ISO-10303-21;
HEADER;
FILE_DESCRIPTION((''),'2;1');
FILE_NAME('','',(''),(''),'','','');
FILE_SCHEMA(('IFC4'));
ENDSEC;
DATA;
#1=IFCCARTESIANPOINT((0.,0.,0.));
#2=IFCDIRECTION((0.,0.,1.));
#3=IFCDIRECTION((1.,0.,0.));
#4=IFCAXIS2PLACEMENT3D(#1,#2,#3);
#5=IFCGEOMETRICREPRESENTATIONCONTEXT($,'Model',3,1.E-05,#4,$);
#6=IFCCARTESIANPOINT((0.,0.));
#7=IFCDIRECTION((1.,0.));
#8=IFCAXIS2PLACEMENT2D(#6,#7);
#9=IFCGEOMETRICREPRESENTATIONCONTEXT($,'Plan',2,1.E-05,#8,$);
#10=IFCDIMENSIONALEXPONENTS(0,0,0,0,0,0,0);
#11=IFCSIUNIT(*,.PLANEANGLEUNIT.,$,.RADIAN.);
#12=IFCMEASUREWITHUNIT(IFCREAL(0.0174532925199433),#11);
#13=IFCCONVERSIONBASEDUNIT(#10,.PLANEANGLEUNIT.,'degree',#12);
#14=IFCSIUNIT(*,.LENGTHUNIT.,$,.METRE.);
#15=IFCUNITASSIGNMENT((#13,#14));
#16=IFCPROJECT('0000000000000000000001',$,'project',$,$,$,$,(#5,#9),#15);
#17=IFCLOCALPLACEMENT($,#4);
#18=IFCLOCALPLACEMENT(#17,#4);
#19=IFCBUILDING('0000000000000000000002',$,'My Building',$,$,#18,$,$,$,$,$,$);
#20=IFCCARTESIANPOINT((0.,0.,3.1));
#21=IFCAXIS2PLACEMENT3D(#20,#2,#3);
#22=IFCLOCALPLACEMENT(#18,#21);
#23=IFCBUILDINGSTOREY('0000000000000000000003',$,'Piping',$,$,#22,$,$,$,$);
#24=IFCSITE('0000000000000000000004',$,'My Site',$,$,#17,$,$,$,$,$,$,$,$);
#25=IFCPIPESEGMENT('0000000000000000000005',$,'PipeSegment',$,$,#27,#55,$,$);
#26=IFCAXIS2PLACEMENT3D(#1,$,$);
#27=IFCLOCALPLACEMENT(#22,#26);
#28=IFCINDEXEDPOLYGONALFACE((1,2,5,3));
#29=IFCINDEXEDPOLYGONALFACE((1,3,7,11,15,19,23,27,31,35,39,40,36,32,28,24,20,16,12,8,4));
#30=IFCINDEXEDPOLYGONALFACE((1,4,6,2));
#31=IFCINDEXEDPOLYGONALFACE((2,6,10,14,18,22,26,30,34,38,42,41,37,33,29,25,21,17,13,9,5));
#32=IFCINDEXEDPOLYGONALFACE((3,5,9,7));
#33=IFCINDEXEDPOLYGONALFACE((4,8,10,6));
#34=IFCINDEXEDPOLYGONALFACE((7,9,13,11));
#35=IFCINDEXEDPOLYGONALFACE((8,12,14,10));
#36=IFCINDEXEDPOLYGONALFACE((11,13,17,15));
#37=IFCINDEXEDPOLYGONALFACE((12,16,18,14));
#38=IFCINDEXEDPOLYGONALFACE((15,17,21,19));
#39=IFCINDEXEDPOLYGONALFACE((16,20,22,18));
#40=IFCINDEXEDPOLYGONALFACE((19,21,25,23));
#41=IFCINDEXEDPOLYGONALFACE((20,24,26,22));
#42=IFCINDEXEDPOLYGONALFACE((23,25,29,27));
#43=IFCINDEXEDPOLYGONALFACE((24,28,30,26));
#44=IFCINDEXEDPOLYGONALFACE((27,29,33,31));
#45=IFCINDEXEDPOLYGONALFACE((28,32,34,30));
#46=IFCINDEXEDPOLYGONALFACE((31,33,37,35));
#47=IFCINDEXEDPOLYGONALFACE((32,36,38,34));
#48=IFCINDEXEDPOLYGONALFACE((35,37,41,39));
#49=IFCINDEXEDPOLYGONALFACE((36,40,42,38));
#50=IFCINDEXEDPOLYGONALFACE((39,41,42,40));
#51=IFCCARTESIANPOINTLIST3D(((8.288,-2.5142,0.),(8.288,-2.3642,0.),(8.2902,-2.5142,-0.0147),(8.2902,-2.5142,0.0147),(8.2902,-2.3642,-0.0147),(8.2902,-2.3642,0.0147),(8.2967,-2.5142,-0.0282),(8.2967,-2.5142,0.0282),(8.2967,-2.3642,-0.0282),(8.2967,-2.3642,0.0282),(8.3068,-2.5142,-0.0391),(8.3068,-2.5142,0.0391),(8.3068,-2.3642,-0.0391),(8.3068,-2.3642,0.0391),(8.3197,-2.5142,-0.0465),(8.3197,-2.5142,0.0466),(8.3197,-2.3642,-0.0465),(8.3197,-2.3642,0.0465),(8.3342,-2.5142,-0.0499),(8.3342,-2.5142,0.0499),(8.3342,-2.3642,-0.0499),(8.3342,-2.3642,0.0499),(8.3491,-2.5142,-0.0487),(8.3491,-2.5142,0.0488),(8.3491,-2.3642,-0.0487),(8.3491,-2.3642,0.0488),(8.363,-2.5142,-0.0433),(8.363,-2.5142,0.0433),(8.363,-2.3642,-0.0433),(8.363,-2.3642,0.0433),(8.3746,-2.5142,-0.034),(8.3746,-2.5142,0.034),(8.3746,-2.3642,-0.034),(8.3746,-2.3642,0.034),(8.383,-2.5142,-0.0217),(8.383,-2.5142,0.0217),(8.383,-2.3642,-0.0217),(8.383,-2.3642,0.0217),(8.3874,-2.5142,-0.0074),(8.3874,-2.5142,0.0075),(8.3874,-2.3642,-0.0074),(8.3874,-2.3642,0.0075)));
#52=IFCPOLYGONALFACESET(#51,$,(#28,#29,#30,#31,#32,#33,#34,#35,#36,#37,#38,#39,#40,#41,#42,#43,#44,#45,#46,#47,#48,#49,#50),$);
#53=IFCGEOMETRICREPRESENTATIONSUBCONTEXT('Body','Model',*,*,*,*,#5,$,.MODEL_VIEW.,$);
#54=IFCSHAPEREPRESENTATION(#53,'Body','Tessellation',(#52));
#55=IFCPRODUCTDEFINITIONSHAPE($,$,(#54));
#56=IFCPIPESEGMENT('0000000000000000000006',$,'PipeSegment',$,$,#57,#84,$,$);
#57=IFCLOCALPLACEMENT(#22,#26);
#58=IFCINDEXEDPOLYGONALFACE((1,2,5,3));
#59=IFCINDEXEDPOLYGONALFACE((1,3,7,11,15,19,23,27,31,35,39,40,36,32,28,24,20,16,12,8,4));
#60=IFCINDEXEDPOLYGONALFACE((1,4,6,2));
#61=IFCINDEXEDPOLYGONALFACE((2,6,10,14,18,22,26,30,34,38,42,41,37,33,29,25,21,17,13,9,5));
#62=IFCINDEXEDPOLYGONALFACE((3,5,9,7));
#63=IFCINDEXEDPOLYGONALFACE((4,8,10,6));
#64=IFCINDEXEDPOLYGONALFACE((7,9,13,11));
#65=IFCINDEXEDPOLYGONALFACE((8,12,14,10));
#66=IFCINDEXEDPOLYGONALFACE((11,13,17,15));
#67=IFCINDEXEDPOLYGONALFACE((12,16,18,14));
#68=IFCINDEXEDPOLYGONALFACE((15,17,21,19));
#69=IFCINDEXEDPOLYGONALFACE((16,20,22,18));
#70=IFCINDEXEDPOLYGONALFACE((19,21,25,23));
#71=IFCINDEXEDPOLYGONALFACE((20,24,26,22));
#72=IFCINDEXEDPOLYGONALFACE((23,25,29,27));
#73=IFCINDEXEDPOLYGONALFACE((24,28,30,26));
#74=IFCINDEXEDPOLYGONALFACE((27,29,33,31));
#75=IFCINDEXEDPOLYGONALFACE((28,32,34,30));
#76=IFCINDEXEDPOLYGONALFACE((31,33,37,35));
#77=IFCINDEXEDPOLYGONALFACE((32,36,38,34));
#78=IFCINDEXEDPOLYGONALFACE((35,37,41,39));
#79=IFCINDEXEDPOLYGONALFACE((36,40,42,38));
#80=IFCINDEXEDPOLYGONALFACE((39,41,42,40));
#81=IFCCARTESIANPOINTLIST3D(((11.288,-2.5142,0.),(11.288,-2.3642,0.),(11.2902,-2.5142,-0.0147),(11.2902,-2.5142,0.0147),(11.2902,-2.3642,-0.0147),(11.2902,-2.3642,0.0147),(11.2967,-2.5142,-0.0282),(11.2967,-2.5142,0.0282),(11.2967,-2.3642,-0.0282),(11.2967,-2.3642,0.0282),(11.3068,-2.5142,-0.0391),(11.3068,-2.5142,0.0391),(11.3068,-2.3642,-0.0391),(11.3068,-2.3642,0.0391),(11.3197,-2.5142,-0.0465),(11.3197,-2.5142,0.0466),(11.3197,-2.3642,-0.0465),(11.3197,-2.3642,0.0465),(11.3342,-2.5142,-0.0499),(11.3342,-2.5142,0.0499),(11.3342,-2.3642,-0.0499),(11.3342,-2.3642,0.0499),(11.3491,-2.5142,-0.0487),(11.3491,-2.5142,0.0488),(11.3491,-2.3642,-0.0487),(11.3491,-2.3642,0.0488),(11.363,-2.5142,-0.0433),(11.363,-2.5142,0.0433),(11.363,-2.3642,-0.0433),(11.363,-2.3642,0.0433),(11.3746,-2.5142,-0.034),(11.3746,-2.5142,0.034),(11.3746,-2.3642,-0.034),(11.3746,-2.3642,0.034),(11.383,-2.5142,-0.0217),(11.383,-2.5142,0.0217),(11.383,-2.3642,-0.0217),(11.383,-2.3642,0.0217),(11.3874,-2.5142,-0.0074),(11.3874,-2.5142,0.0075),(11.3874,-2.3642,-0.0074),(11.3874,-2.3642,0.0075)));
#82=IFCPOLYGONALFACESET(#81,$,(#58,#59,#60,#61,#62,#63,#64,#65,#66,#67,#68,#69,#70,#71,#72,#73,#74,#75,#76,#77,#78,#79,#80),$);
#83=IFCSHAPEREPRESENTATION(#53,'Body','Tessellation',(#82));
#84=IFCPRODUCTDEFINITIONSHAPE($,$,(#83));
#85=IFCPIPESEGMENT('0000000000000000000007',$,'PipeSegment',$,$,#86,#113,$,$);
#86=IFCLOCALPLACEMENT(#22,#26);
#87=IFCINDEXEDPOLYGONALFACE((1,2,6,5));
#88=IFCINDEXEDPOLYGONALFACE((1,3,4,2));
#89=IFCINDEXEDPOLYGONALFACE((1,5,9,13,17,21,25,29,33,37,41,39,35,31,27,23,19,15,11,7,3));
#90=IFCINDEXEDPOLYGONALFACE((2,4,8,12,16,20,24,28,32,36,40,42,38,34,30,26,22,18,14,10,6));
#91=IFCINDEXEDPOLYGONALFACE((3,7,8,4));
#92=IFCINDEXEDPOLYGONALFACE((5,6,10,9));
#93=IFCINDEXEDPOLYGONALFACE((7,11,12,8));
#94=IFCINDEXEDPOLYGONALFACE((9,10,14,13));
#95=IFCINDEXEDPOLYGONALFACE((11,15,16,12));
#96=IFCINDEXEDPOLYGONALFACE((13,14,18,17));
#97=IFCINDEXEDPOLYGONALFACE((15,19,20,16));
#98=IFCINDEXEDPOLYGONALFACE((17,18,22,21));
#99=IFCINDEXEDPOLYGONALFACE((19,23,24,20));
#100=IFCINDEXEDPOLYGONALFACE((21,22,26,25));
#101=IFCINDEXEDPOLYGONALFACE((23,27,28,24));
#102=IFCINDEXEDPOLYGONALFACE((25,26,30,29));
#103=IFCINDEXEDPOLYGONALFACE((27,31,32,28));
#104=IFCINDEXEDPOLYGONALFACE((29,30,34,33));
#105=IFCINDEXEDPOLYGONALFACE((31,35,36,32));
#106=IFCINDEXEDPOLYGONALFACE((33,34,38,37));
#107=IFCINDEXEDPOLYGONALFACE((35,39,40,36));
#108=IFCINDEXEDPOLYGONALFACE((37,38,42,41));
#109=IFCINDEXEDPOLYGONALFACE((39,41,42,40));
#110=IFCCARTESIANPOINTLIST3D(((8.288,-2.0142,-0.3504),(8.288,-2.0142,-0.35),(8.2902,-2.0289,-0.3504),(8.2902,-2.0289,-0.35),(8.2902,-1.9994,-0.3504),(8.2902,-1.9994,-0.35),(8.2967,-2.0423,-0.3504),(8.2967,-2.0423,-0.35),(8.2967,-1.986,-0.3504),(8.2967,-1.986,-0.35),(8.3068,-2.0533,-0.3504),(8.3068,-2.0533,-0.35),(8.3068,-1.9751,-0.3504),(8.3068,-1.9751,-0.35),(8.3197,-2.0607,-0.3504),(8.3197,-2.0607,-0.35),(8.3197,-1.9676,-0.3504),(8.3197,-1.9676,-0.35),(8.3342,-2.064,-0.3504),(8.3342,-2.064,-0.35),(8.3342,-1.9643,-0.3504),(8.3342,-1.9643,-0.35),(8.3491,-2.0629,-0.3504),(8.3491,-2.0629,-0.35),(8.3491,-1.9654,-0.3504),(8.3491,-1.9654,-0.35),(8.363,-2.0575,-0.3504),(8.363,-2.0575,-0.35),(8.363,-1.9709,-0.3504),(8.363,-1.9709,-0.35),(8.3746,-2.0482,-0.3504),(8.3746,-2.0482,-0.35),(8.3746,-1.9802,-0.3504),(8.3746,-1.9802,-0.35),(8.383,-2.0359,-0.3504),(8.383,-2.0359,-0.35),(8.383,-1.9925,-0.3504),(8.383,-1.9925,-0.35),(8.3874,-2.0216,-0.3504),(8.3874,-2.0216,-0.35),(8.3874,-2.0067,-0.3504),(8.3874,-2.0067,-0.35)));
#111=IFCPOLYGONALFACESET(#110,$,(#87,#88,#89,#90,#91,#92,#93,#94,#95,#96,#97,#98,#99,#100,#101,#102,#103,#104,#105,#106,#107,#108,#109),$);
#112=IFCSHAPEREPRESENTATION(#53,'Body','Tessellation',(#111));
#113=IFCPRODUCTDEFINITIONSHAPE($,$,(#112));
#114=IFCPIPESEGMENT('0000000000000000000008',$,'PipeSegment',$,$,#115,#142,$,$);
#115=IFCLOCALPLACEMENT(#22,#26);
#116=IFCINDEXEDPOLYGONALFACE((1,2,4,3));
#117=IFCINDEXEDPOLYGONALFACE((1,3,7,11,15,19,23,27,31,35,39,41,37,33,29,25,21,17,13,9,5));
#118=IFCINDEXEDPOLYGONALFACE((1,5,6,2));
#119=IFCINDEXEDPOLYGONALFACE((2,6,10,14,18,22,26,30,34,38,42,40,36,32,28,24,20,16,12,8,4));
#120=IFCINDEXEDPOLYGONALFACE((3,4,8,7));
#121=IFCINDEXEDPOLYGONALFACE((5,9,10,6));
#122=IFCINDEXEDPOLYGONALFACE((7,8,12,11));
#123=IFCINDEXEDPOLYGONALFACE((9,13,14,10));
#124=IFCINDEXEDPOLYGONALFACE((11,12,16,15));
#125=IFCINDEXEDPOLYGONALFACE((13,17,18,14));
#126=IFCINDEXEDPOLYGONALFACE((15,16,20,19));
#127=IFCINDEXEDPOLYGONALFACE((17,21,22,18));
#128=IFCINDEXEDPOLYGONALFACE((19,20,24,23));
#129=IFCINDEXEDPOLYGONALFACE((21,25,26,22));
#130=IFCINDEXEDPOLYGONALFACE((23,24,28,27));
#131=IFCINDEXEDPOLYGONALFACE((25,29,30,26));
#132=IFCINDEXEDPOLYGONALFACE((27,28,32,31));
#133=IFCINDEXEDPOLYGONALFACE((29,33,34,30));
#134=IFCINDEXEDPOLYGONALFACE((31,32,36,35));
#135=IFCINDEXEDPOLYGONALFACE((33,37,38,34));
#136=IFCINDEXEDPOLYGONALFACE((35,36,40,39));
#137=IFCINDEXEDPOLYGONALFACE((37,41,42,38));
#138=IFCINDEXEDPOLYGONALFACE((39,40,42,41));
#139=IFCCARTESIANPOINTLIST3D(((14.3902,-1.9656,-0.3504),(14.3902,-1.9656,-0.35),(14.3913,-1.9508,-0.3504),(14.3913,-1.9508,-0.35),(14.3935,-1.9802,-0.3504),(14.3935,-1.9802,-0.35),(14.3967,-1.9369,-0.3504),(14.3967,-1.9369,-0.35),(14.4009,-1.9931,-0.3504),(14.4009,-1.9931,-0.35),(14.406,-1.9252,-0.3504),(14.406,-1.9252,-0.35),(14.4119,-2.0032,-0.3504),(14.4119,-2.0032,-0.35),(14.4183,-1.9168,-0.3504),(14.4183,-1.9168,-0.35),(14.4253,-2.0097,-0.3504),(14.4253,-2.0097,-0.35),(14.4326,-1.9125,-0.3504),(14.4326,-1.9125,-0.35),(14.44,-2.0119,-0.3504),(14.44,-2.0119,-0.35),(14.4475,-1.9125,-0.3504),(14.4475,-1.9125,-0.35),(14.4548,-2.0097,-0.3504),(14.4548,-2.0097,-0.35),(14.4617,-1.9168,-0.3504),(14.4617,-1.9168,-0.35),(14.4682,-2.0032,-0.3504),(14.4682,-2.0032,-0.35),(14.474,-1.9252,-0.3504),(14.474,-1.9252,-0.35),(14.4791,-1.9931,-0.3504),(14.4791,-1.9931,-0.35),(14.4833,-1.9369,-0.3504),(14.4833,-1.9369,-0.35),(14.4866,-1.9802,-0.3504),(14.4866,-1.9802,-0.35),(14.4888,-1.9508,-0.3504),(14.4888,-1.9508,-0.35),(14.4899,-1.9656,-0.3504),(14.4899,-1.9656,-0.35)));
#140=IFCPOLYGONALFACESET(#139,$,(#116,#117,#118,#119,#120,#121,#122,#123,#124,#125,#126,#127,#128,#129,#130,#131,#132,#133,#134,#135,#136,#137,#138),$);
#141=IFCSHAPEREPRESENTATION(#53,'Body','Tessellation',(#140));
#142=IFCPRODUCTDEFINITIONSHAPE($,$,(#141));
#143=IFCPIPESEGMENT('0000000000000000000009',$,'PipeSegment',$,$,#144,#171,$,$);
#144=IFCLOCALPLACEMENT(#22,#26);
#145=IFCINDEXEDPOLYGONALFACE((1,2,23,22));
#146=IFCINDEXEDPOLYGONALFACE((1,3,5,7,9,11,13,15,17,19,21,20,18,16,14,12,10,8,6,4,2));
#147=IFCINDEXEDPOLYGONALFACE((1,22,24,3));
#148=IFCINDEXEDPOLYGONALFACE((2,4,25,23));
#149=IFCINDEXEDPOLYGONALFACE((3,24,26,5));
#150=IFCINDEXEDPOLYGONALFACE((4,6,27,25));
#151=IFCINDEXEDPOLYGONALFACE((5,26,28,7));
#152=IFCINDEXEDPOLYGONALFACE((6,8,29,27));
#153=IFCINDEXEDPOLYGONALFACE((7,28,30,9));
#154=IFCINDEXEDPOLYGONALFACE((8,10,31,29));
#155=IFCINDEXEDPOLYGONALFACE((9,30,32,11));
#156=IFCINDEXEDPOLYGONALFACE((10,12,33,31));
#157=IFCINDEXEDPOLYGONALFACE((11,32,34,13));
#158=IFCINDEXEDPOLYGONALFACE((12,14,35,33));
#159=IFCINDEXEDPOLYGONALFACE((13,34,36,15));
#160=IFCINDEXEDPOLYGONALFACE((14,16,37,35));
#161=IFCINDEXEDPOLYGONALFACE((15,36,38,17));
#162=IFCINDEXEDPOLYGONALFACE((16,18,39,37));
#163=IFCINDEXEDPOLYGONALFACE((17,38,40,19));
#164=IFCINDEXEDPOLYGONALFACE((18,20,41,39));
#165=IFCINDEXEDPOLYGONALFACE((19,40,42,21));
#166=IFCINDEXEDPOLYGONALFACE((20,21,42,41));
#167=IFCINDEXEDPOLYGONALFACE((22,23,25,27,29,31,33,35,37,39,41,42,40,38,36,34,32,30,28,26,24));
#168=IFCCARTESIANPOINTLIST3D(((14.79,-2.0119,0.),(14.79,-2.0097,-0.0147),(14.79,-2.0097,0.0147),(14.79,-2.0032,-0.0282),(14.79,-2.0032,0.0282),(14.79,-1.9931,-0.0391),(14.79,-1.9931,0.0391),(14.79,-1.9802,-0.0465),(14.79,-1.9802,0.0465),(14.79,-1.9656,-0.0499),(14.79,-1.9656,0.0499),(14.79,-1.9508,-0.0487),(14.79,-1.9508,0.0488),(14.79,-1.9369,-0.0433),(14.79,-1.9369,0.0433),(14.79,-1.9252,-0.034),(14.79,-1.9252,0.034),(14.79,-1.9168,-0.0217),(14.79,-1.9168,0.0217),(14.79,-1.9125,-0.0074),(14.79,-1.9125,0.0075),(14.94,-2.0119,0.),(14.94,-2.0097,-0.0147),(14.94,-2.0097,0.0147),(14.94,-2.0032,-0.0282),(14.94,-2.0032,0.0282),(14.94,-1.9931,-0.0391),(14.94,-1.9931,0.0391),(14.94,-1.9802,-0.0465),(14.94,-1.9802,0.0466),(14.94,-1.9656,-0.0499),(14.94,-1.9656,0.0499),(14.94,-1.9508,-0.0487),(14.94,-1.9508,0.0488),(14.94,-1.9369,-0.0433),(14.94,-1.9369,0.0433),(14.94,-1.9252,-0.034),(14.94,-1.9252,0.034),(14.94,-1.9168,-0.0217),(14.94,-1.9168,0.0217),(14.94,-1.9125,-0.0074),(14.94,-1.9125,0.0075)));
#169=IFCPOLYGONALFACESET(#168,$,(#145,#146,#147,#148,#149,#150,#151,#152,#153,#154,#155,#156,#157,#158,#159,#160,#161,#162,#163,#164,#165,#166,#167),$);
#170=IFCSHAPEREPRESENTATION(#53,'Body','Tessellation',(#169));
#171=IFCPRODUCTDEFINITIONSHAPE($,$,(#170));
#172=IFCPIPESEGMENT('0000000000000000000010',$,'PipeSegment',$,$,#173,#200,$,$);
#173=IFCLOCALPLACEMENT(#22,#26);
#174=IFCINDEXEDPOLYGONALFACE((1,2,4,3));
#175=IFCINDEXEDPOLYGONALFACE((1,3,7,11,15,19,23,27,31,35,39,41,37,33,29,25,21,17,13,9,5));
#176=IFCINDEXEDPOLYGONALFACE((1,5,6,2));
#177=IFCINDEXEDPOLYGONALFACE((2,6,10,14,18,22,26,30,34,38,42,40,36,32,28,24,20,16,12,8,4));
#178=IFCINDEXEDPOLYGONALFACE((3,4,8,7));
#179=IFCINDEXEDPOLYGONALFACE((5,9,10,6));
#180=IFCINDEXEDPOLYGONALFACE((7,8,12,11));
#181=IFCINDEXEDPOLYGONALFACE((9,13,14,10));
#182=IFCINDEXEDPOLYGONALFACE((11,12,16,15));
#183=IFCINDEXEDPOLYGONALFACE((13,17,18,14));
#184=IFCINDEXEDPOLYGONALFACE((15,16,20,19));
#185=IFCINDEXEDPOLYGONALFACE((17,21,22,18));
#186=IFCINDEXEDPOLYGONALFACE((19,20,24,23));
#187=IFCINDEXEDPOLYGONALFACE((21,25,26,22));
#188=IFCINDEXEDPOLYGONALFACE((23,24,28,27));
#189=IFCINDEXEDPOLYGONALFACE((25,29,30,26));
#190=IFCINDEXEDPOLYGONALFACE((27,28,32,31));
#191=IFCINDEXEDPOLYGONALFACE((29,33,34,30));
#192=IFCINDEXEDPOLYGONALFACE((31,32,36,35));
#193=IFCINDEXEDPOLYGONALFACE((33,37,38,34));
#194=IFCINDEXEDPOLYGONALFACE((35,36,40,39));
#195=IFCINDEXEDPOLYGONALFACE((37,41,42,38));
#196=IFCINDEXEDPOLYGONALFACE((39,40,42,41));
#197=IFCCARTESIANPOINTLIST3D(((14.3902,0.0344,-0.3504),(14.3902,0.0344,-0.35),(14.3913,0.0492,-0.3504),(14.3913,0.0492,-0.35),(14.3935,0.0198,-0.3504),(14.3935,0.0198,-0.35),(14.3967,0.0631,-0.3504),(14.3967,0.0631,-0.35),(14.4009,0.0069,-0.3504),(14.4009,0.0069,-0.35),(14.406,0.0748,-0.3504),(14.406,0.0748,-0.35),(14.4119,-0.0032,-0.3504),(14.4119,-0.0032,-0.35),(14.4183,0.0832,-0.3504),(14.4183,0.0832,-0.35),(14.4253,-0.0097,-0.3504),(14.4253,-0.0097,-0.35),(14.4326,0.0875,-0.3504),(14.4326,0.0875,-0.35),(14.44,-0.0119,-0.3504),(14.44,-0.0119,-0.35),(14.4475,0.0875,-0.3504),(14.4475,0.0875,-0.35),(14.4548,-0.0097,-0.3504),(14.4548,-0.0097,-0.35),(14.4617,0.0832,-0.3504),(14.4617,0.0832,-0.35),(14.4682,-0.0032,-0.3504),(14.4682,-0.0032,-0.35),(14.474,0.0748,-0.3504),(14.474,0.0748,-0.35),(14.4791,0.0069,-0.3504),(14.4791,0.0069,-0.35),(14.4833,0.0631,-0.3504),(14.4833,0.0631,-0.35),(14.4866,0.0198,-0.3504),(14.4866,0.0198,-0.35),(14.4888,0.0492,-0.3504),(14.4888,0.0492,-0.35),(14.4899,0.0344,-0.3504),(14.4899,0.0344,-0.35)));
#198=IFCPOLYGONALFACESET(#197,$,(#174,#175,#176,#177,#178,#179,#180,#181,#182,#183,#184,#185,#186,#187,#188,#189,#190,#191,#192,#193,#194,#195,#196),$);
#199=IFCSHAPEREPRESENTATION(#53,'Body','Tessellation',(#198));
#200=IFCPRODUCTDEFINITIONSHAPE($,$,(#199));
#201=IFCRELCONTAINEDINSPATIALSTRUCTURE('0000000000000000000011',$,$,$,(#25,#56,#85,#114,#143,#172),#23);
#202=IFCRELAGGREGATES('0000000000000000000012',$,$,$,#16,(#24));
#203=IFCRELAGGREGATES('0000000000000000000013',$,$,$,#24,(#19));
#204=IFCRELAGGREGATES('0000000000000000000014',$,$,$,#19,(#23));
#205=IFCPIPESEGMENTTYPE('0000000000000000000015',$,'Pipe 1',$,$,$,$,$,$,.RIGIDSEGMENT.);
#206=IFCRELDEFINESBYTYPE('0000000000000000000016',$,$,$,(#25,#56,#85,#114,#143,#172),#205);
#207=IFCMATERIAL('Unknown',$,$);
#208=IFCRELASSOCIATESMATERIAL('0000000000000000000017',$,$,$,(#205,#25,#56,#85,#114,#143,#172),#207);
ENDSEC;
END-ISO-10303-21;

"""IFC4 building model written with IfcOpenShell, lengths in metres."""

from ifc_helpers import new_model, entity, si_unit, converted_unit, frame, origin_with_axes, origin_2d_with_axis, place, context, subcontext, project, spatial, circle, extrude, material, material_profile, profile_set, profile_usage, type_object, element, save


model = new_model("IFC4")

# Units and contexts
model_context = context("Model", 3, precision=1e-05, world=origin_with_axes())
plan_context = context("Plan", 2, precision=1e-05, world=origin_2d_with_axis())
body_context = subcontext(model_context, "Body", "Model", "MODEL_VIEW")
ifc_project = project(units=[converted_unit("PLANEANGLEUNIT", "degree", entity("IfcReal", 0.0174532925199433), si_unit("PLANEANGLEUNIT", "RADIAN"), dimensions=[0, 0, 0, 0, 0, 0, 0]), si_unit("LENGTHUNIT", "METRE")], contexts=[model_context, plan_context])

# Site, building, storey
site_placement = place(None, origin_with_axes())
site = spatial("IfcSite", under=ifc_project, at=site_placement, Name="My Site")
building_placement = place(site_placement, origin_with_axes())
building = spatial("IfcBuilding", under=site, at=building_placement, Name="My Building")
storey_placement = place(building_placement, frame((0.0, 0.0, 3.1), z_axis=(0.0, 0.0, 1.0), x_axis=(1.0, 0.0, 0.0)))
storey = spatial("IfcBuildingStorey", under=building, at=storey_placement, Name="Piping")

# Pipe segments
ifc_material = material(Name="Unknown")
ifc_material_profile = material_profile(ifc_material, circle(Radius=0.05))
ifc_profile_set = profile_set([ifc_material_profile])
pipe_segment_type = type_object("IfcPipeSegmentType", Name="Pipe 1", PredefinedType="RIGIDSEGMENT", material=ifc_profile_set)
ifc_profile_usage_1 = profile_usage(ifc_profile_set, cardinal=5)
pipe_segment_1_placement = place(storey_placement, frame((8.338, -2.5142, 0.0), z_axis=(0.0, 1.0, -0.000022), x_axis=(-1.0, 0.0, 0.0)))
element("IfcPipeSegment", 1, at=pipe_segment_1_placement, inside=storey, type_object=pipe_segment_type, material=ifc_profile_usage_1, Name="PipeSegment", context=body_context, shape_type="SweptSolid", body=[
    extrude(circle(Radius=0.05), origin_with_axes(), (0.0, 0.0, 1.0), 0.15),
])
ifc_profile_usage_2 = profile_usage(ifc_profile_set, cardinal=5)
pipe_segment_2_placement = place(storey_placement, frame((11.338, -2.5142, 0.0), z_axis=(0.0, 1.0, -0.000022), x_axis=(-1.0, 0.0, 0.0)))
element("IfcPipeSegment", 2, at=pipe_segment_2_placement, inside=storey, type_object=pipe_segment_type, material=ifc_profile_usage_2, Name="PipeSegment", context=body_context, shape_type="SweptSolid", body=[
    extrude(circle(Radius=0.05), origin_with_axes(), (0.0, 0.0, 1.0), 0.15),
])
ifc_profile_usage_3 = profile_usage(ifc_profile_set, cardinal=5)
pipe_segment_3_placement = place(storey_placement, frame((8.338, -2.0142, -0.35), z_axis=(0.0, 0.0, -1.0), x_axis=(-1.0, 0.0, 0.0)))
element("IfcPipeSegment", 3, at=pipe_segment_3_placement, inside=storey, type_object=pipe_segment_type, material=ifc_profile_usage_3, Name="PipeSegment", context=body_context, shape_type="SweptSolid", body=[
    extrude(circle(Radius=0.05), origin_with_axes(), (0.0, 0.0, 1.0), 0.0004),
])
ifc_profile_usage_4 = profile_usage(ifc_profile_set, cardinal=5)
pipe_segment_4_placement = place(storey_placement, frame((14.44, -1.9619, -0.35), z_axis=(0.0, 0.0, -1.0), x_axis=(0.0, -1.0, 0.0)))
element("IfcPipeSegment", 4, at=pipe_segment_4_placement, inside=storey, type_object=pipe_segment_type, material=ifc_profile_usage_4, Name="PipeSegment", context=body_context, shape_type="SweptSolid", body=[
    extrude(circle(Radius=0.05), origin_with_axes(), (0.0, 0.0, 1.0), 0.0004),
])
ifc_profile_usage_5 = profile_usage(ifc_profile_set, cardinal=5)
pipe_segment_5_placement = place(storey_placement, frame((14.94, -1.9619, 0.0), z_axis=(-1.0, 0.0, -0.000022), x_axis=(0.0, -1.0, 0.0)))
element("IfcPipeSegment", 5, at=pipe_segment_5_placement, inside=storey, type_object=pipe_segment_type, material=ifc_profile_usage_5, Name="PipeSegment", context=body_context, shape_type="SweptSolid", body=[
    extrude(circle(Radius=0.05), origin_with_axes(), (0.0, 0.0, 1.0), 0.15),
])
ifc_profile_usage_6 = profile_usage(ifc_profile_set, cardinal=5)
pipe_segment_6_placement = place(storey_placement, frame((14.44, 0.0381, -0.35), z_axis=(0.0, 0.0, -1.0), x_axis=(0.0, -1.0, 0.0)))
element("IfcPipeSegment", 6, at=pipe_segment_6_placement, inside=storey, type_object=pipe_segment_type, material=ifc_profile_usage_6, Name="PipeSegment", context=body_context, shape_type="SweptSolid", body=[
    extrude(circle(Radius=0.05), origin_with_axes(), (0.0, 0.0, 1.0), 0.0004),
])

save(model, "model.ifc")
